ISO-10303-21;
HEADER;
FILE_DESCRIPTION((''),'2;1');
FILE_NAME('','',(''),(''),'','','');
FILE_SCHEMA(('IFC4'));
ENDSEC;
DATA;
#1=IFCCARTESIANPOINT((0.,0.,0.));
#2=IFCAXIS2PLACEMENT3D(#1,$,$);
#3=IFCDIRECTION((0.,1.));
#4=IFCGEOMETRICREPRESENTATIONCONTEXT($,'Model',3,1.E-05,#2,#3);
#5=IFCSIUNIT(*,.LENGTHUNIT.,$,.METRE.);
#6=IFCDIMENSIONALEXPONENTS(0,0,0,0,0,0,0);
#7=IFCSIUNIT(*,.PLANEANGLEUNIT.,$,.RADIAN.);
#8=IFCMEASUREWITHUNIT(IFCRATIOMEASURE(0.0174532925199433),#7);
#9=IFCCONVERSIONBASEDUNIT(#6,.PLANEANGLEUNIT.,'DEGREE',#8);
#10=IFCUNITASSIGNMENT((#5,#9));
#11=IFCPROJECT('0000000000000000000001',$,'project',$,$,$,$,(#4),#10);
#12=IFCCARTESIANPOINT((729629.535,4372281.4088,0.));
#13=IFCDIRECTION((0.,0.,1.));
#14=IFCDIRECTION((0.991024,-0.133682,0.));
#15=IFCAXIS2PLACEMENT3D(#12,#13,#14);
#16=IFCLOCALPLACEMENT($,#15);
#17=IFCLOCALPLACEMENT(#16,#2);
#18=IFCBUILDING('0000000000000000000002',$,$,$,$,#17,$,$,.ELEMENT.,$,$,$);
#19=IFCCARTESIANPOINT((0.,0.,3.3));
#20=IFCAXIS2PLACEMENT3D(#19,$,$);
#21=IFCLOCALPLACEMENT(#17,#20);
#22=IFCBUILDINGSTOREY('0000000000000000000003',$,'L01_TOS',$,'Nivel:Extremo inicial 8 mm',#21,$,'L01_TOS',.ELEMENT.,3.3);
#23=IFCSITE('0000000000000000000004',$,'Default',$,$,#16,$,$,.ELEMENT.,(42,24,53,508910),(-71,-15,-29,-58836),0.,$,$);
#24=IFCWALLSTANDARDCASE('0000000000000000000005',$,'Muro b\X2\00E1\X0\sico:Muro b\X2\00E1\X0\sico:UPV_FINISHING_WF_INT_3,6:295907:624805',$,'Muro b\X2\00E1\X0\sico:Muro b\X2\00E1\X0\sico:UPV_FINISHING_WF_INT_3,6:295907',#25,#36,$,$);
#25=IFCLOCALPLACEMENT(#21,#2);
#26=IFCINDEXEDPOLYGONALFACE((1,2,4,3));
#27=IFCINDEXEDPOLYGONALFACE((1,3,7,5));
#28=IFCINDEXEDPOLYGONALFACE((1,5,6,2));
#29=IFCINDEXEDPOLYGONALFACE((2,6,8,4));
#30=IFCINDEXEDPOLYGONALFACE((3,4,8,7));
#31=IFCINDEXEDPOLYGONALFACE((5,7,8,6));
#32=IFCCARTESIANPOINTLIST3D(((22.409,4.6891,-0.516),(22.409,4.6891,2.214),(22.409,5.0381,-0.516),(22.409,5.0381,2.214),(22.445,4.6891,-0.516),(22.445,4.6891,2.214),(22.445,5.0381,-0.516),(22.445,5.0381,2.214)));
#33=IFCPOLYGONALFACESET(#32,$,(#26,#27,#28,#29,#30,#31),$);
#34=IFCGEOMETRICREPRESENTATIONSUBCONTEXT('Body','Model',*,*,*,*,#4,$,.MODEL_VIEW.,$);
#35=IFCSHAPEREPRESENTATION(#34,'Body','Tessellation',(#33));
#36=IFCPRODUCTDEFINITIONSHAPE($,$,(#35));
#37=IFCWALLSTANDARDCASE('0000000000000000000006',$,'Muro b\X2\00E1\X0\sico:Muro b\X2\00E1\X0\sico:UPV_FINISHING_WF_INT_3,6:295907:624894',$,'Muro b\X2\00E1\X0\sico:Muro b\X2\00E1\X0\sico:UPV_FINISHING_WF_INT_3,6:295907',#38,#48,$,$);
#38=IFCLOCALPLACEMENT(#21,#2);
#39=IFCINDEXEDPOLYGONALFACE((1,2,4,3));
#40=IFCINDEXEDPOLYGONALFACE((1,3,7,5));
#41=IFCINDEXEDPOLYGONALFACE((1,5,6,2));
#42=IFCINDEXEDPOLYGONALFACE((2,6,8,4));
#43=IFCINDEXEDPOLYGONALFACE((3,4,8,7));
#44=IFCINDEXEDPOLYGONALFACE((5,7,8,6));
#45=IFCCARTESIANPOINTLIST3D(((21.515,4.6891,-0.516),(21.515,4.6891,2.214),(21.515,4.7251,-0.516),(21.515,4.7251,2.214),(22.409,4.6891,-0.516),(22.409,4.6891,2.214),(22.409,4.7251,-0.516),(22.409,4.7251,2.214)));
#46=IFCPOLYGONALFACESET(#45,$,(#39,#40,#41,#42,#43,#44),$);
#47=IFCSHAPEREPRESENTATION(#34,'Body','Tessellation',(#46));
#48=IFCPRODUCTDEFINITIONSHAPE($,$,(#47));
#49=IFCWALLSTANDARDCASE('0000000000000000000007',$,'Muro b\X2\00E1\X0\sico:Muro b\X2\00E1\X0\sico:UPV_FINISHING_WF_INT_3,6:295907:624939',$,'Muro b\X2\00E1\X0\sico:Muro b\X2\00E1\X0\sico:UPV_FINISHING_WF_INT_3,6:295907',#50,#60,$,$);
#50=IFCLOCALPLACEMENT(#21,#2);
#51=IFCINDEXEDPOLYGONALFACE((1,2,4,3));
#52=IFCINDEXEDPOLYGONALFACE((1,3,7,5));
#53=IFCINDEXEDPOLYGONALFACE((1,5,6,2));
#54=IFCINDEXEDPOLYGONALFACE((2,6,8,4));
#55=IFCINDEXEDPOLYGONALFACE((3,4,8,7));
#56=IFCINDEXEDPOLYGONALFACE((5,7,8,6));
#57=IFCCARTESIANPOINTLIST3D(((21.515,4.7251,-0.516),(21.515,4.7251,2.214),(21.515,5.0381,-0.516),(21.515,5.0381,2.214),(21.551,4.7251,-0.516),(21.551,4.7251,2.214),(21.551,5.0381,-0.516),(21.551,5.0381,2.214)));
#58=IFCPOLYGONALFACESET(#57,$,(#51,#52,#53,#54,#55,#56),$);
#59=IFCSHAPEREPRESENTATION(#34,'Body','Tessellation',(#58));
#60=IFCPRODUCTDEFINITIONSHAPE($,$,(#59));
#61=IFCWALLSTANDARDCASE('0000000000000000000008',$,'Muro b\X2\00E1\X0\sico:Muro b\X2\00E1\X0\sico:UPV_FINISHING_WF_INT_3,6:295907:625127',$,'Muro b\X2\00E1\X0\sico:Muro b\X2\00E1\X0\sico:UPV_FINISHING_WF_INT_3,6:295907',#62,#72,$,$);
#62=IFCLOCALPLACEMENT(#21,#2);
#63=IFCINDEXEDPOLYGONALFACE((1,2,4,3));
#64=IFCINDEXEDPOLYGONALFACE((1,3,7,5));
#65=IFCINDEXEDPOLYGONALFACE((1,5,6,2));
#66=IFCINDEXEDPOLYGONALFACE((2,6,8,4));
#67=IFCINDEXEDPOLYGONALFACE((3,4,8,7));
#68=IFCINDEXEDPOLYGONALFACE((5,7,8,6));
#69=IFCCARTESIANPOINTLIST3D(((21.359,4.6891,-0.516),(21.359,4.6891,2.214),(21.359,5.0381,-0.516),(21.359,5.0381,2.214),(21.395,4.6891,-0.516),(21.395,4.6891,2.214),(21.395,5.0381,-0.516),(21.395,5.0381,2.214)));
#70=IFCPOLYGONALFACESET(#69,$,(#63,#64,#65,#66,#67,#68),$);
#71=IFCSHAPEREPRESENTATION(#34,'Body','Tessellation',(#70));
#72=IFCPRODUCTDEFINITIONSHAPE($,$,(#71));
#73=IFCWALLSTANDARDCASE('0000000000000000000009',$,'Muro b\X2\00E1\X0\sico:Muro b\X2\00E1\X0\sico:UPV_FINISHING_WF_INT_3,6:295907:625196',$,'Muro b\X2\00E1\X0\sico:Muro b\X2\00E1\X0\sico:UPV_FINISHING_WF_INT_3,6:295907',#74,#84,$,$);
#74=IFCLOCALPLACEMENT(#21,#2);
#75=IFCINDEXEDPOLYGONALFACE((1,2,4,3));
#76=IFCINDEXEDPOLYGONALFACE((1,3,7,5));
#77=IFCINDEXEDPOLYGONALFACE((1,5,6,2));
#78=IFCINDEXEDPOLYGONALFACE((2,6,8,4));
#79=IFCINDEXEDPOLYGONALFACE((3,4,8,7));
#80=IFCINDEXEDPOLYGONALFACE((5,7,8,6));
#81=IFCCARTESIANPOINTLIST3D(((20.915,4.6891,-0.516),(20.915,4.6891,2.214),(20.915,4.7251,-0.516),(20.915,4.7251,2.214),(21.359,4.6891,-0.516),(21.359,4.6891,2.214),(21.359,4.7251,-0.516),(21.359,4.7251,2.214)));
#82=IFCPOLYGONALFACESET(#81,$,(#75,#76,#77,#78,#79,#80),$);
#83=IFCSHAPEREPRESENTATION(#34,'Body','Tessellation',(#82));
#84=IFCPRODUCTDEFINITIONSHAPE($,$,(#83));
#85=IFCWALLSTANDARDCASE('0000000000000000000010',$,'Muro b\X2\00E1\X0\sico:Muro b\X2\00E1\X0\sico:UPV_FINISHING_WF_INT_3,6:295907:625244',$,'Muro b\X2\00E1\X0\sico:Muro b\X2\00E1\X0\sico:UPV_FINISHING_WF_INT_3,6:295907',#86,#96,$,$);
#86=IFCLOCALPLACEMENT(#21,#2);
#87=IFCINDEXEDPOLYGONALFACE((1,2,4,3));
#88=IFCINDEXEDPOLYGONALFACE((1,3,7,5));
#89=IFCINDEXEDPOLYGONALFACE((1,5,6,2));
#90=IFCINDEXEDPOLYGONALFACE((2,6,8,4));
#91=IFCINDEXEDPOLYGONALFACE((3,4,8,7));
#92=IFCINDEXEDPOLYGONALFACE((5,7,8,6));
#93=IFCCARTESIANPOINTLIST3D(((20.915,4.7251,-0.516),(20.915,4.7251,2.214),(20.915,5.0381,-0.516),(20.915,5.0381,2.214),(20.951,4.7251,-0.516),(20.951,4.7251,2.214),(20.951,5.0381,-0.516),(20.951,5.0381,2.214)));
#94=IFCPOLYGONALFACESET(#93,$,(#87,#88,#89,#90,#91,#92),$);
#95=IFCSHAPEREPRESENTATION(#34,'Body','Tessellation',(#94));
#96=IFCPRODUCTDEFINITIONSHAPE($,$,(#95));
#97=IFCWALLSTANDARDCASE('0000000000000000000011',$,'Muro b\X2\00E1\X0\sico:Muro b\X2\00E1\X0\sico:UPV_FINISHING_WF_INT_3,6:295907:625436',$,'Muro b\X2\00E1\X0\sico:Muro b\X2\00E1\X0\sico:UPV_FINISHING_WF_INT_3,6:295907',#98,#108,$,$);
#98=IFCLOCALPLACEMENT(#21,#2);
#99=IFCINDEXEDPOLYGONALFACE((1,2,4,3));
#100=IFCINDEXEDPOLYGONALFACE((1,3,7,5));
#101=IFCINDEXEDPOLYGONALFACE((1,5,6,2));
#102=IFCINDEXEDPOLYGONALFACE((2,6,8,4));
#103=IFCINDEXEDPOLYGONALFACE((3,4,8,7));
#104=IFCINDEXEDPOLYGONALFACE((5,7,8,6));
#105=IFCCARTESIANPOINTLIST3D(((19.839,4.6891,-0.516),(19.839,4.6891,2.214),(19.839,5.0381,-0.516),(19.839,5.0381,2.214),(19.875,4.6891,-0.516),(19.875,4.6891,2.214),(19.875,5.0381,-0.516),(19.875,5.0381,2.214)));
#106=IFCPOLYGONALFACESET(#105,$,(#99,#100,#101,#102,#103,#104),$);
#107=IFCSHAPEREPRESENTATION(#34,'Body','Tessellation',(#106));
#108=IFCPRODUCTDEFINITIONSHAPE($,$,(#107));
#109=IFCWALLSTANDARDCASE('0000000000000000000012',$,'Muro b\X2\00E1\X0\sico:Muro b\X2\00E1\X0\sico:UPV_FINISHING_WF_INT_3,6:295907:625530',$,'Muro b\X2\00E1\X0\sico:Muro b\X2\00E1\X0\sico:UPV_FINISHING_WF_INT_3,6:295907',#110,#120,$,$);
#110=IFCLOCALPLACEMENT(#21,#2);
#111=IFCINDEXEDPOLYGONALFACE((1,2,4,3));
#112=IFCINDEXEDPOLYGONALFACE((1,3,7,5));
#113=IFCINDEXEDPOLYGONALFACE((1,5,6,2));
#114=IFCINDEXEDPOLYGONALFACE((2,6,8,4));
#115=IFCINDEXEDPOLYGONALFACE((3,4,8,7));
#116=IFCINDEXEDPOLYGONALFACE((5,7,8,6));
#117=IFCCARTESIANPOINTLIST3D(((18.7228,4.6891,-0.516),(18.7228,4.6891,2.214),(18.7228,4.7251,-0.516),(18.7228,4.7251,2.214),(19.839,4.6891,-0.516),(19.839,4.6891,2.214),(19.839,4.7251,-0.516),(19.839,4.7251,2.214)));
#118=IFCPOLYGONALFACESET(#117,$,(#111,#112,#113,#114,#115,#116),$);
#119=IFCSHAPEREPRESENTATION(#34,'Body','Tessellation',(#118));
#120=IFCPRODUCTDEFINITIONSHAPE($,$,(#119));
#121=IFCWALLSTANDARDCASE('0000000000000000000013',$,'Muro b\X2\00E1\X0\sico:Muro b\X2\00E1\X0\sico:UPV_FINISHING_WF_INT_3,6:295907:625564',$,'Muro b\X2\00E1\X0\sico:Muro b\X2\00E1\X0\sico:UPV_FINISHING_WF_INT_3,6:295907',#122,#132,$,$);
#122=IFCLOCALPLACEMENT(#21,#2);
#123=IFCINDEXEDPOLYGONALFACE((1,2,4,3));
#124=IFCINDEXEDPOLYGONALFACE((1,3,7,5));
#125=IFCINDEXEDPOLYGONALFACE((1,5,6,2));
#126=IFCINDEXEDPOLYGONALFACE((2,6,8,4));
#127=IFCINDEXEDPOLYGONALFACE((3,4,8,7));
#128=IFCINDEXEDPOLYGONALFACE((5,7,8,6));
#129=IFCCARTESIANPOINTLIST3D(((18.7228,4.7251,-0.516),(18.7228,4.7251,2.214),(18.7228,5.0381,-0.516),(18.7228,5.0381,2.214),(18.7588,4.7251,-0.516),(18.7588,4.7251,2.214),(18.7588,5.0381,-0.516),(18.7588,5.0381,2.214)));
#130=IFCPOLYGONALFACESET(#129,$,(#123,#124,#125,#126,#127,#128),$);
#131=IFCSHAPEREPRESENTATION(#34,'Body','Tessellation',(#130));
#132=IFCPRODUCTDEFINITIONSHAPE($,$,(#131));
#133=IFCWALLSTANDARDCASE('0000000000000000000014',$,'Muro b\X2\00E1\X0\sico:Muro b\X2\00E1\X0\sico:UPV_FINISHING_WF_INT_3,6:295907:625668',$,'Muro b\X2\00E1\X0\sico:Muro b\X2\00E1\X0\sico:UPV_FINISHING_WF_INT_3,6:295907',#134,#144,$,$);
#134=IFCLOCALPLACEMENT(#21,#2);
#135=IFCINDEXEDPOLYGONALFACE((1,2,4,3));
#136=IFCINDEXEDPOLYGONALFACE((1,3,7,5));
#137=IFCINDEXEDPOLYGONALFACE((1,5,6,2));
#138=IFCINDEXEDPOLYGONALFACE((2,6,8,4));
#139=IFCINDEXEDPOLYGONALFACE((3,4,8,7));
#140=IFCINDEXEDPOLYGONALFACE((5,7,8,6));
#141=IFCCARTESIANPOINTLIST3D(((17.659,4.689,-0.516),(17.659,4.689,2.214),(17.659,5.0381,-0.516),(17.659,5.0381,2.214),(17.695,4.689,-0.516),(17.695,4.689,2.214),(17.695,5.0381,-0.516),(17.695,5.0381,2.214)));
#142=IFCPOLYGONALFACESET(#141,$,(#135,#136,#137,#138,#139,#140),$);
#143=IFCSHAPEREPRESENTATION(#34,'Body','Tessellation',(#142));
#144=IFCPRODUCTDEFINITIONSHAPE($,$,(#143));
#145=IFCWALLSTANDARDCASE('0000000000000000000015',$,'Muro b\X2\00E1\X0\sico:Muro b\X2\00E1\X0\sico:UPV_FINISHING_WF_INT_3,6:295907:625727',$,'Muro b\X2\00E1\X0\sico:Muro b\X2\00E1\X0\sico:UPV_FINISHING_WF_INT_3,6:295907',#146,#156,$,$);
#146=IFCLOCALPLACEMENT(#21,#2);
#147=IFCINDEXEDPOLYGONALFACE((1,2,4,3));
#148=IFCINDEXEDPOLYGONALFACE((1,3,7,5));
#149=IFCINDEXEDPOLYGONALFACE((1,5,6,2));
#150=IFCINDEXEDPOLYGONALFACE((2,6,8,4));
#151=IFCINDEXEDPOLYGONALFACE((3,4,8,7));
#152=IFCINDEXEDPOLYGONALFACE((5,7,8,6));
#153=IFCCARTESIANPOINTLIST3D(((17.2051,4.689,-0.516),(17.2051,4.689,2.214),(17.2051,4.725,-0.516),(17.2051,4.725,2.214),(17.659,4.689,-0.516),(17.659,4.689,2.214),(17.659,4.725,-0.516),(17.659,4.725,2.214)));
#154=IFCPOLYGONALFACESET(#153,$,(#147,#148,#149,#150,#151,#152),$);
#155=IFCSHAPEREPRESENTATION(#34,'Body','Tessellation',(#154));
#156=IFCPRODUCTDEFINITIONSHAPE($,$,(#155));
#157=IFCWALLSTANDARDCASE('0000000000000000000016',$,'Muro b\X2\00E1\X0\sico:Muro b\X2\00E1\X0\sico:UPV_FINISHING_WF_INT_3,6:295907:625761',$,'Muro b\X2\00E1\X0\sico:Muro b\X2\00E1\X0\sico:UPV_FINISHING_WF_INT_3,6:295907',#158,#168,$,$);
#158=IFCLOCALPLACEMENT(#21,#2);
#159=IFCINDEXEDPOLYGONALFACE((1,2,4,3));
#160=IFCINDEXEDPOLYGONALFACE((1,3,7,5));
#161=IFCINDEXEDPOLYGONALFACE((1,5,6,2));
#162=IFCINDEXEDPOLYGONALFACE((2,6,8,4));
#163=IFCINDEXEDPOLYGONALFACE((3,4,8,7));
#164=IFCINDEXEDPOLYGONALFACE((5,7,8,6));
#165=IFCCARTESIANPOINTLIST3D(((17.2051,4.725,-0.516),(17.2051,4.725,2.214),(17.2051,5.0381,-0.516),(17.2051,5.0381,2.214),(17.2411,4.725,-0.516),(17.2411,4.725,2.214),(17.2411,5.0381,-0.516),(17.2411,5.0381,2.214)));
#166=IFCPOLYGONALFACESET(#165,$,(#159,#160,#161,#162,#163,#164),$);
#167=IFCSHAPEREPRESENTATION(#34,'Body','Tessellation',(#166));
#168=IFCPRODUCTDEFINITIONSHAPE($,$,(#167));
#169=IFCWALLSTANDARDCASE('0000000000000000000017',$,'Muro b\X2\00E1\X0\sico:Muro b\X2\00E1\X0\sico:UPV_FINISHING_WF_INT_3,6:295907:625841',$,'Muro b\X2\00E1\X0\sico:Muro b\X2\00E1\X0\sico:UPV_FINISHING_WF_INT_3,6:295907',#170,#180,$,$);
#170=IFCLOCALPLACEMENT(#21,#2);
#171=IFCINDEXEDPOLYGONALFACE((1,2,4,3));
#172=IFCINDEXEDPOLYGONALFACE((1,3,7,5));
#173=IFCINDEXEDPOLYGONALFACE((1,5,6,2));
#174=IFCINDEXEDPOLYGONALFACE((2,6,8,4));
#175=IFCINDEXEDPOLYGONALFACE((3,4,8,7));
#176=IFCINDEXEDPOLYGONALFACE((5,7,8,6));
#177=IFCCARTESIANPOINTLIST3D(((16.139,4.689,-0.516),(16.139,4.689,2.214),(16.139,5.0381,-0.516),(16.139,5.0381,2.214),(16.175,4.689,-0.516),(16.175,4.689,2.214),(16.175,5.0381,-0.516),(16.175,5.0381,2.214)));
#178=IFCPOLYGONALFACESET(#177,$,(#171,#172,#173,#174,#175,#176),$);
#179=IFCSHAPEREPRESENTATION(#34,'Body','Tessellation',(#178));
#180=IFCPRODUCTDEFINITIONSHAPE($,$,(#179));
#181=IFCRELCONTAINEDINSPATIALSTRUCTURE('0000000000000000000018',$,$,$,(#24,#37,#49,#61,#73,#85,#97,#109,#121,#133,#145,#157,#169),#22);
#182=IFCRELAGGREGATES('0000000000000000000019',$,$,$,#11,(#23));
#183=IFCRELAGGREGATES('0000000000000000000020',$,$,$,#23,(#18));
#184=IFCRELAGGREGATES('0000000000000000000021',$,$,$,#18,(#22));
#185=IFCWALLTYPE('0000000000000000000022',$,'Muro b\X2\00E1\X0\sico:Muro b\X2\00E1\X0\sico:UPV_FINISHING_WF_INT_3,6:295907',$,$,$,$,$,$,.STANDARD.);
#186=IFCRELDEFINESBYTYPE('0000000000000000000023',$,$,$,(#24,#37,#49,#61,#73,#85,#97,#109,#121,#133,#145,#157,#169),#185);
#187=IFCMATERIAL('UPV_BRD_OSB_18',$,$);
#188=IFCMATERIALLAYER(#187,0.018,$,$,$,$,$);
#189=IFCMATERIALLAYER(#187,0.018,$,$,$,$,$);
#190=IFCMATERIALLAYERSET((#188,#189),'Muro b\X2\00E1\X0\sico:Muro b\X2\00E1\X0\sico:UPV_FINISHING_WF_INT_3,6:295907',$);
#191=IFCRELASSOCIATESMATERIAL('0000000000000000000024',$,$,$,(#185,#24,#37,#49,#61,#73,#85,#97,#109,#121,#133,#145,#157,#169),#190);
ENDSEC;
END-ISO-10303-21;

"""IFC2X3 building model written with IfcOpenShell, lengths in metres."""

from ifc_helpers import new_model, entity, si_unit, converted_unit, direction, frame, frame_2d, origin, place, context, subcontext, project, spatial, rectangle, extrude, material, layer, layer_set, layer_usage, type_object, element, save


model = new_model("IFC2X3")

# Units and contexts
model_context = context("Model", 3, precision=1e-05, world=origin(), true_north=direction((0.0, 1.0)))
body_context = subcontext(model_context, "Body", "Model", "MODEL_VIEW")
ifc_project = project(units=[si_unit("LENGTHUNIT", "METRE"), converted_unit("PLANEANGLEUNIT", "DEGREE", entity("IfcRatioMeasure", 0.0174532925199433), si_unit("PLANEANGLEUNIT", "RADIAN"), dimensions=[0, 0, 0, 0, 0, 0, 0])], contexts=[model_context])

# Site, building, storey
site_placement = place(None, frame((729629.535, 4372281.4088, 0.0), z_axis=(0.0, 0.0, 1.0), x_axis=(0.991024, -0.133682, 0.0)))
site = spatial("IfcSite", under=ifc_project, at=site_placement, Name="Default", CompositionType="ELEMENT", RefLatitude=(42, 24, 53, 508910), RefLongitude=(-71, -15, -29, -58836), RefElevation=0.0)
building_placement = place(site_placement, origin())
building = spatial("IfcBuilding", under=site, at=building_placement, CompositionType="ELEMENT")
storey_placement = place(building_placement, frame((0.0, 0.0, 3.3)))
storey = spatial("IfcBuildingStorey", under=building, at=storey_placement, Name="L01_TOS", ObjectType="Nivel:Extremo inicial 8 mm", LongName="L01_TOS", CompositionType="ELEMENT", Elevation=3.3)

# Walls
ifc_material_1 = material(Name="UPV_BRD_OSB_18")
ifc_layer_1 = layer(ifc_material_1, 0.018)
ifc_layer_2 = layer(ifc_material_1, 0.018)
ifc_layer_set_1 = layer_set([ifc_layer_1, ifc_layer_2], Name="Muro básico:Muro básico:UPV_FINISHING_WF_INT_3,6:295907")
ifc_layer_usage_1 = layer_usage(ifc_layer_set_1, "AXIS2", "NEGATIVE", 0.018)
wall_type_1 = type_object("IfcWallType", Name="Muro básico:Muro básico:UPV_FINISHING_WF_INT_3,6:295907", PredefinedType="STANDARD", material=ifc_layer_set_1)
wall_1_placement = place(storey_placement, frame((22.427, 5.0381, -0.516), z_axis=(0.0, 0.0, 1.0), x_axis=(0.0, -1.0, 0.0)))
element("IfcWallStandardCase", 1, at=wall_1_placement, inside=storey, type_object=wall_type_1, material=ifc_layer_usage_1, Name="Muro básico:Muro básico:UPV_FINISHING_WF_INT_3,6:295907:624805", ObjectType="Muro básico:Muro básico:UPV_FINISHING_WF_INT_3,6:295907", context=body_context, shape_type="SweptSolid", body=[
    extrude(rectangle(XDim=0.349, YDim=0.036, at=frame_2d((0.1745, 0.0), x_axis=(-1.0, 0.0))), origin(), (0.0, 0.0, 1.0), 2.73),
])
ifc_layer_usage_2 = layer_usage(ifc_layer_set_1, "AXIS2", "POSITIVE", -0.018)
wall_2_placement = place(storey_placement, frame((22.409, 4.7071, -0.516), z_axis=(0.0, 0.0, 1.0), x_axis=(-1.0, -0.000012, 0.0)))
element("IfcWallStandardCase", 2, at=wall_2_placement, inside=storey, type_object=wall_type_1, material=ifc_layer_usage_2, Name="Muro básico:Muro básico:UPV_FINISHING_WF_INT_3,6:295907:624894", ObjectType="Muro básico:Muro básico:UPV_FINISHING_WF_INT_3,6:295907", context=body_context, shape_type="SweptSolid", body=[
    extrude(rectangle(XDim=0.894, YDim=0.036, at=frame_2d((0.447, 0.0), x_axis=(-1.0, 0.0))), origin(), (0.0, 0.0, 1.0), 2.73),
])
ifc_layer_usage_3 = layer_usage(ifc_layer_set_1, "AXIS2", "NEGATIVE", 0.018)
wall_3_placement = place(storey_placement, frame((21.533, 4.7251, -0.516), z_axis=(0.0, 0.0, 1.0), x_axis=(0.0, 1.0, 0.0)))
element("IfcWallStandardCase", 3, at=wall_3_placement, inside=storey, type_object=wall_type_1, material=ifc_layer_usage_3, Name="Muro básico:Muro básico:UPV_FINISHING_WF_INT_3,6:295907:624939", ObjectType="Muro básico:Muro básico:UPV_FINISHING_WF_INT_3,6:295907", context=body_context, shape_type="SweptSolid", body=[
    extrude(rectangle(XDim=0.313, YDim=0.036, at=frame_2d((0.1565, 0.0), x_axis=(-1.0, 0.0))), origin(), (0.0, 0.0, 1.0), 2.73),
])
ifc_layer_usage_4 = layer_usage(ifc_layer_set_1, "AXIS2", "NEGATIVE", 0.018)
wall_4_placement = place(storey_placement, frame((21.377, 5.0381, -0.516), z_axis=(0.0, 0.0, 1.0), x_axis=(0.0, -1.0, 0.0)))
element("IfcWallStandardCase", 4, at=wall_4_placement, inside=storey, type_object=wall_type_1, material=ifc_layer_usage_4, Name="Muro básico:Muro básico:UPV_FINISHING_WF_INT_3,6:295907:625127", ObjectType="Muro básico:Muro básico:UPV_FINISHING_WF_INT_3,6:295907", context=body_context, shape_type="SweptSolid", body=[
    extrude(rectangle(XDim=0.349, YDim=0.036, at=frame_2d((0.1745, 0.0), x_axis=(-1.0, 0.0))), origin(), (0.0, 0.0, 1.0), 2.73),
])
ifc_layer_usage_5 = layer_usage(ifc_layer_set_1, "AXIS2", "NEGATIVE", 0.018)
wall_5_placement = place(storey_placement, frame((21.359, 4.7071, -0.516), z_axis=(0.0, 0.0, 1.0), x_axis=(-1.0, -0.000012, 0.0)))
element("IfcWallStandardCase", 5, at=wall_5_placement, inside=storey, type_object=wall_type_1, material=ifc_layer_usage_5, Name="Muro básico:Muro básico:UPV_FINISHING_WF_INT_3,6:295907:625196", ObjectType="Muro básico:Muro básico:UPV_FINISHING_WF_INT_3,6:295907", context=body_context, shape_type="SweptSolid", body=[
    extrude(rectangle(XDim=0.444, YDim=0.036, at=frame_2d((0.222, 0.0), x_axis=(-1.0, 0.0))), origin(), (0.0, 0.0, 1.0), 2.73),
])
ifc_layer_usage_6 = layer_usage(ifc_layer_set_1, "AXIS2", "NEGATIVE", 0.018)
wall_6_placement = place(storey_placement, frame((20.933, 4.7251, -0.516), z_axis=(0.0, 0.0, 1.0), x_axis=(0.0, 1.0, 0.0)))
element("IfcWallStandardCase", 6, at=wall_6_placement, inside=storey, type_object=wall_type_1, material=ifc_layer_usage_6, Name="Muro básico:Muro básico:UPV_FINISHING_WF_INT_3,6:295907:625244", ObjectType="Muro básico:Muro básico:UPV_FINISHING_WF_INT_3,6:295907", context=body_context, shape_type="SweptSolid", body=[
    extrude(rectangle(XDim=0.313, YDim=0.036, at=frame_2d((0.1565, 0.0), x_axis=(-1.0, 0.0))), origin(), (0.0, 0.0, 1.0), 2.73),
])
ifc_layer_usage_7 = layer_usage(ifc_layer_set_1, "AXIS2", "NEGATIVE", 0.018)
wall_7_placement = place(storey_placement, frame((19.857, 5.0381, -0.516), z_axis=(0.0, 0.0, 1.0), x_axis=(0.0, -1.0, 0.0)))
element("IfcWallStandardCase", 7, at=wall_7_placement, inside=storey, type_object=wall_type_1, material=ifc_layer_usage_7, Name="Muro básico:Muro básico:UPV_FINISHING_WF_INT_3,6:295907:625436", ObjectType="Muro básico:Muro básico:UPV_FINISHING_WF_INT_3,6:295907", context=body_context, shape_type="SweptSolid", body=[
    extrude(rectangle(XDim=0.349, YDim=0.036, at=frame_2d((0.1745, 0.0), x_axis=(-1.0, 0.0))), origin(), (0.0, 0.0, 1.0), 2.73),
])
ifc_layer_usage_8 = layer_usage(ifc_layer_set_1, "AXIS2", "NEGATIVE", 0.018)
wall_8_placement = place(storey_placement, frame((19.839, 4.7071, -0.516), z_axis=(0.0, 0.0, 1.0), x_axis=(-1.0, -0.000012, 0.0)))
element("IfcWallStandardCase", 8, at=wall_8_placement, inside=storey, type_object=wall_type_1, material=ifc_layer_usage_8, Name="Muro básico:Muro básico:UPV_FINISHING_WF_INT_3,6:295907:625530", ObjectType="Muro básico:Muro básico:UPV_FINISHING_WF_INT_3,6:295907", context=body_context, shape_type="SweptSolid", body=[
    extrude(rectangle(XDim=1.1162, YDim=0.036, at=frame_2d((0.5581, 0.0), x_axis=(-1.0, 0.0))), origin(), (0.0, 0.0, 1.0), 2.73),
])
ifc_layer_usage_9 = layer_usage(ifc_layer_set_1, "AXIS2", "NEGATIVE", 0.018)
wall_9_placement = place(storey_placement, frame((18.7408, 4.7251, -0.516), z_axis=(0.0, 0.0, 1.0), x_axis=(0.0, 1.0, 0.0)))
element("IfcWallStandardCase", 9, at=wall_9_placement, inside=storey, type_object=wall_type_1, material=ifc_layer_usage_9, Name="Muro básico:Muro básico:UPV_FINISHING_WF_INT_3,6:295907:625564", ObjectType="Muro básico:Muro básico:UPV_FINISHING_WF_INT_3,6:295907", context=body_context, shape_type="SweptSolid", body=[
    extrude(rectangle(XDim=0.313, YDim=0.036, at=frame_2d((0.1565, 0.0), x_axis=(-1.0, 0.0))), origin(), (0.0, 0.0, 1.0), 2.73),
])
ifc_layer_usage_10 = layer_usage(ifc_layer_set_1, "AXIS2", "NEGATIVE", 0.018)
wall_10_placement = place(storey_placement, frame((17.677, 5.0381, -0.516), z_axis=(0.0, 0.0, 1.0), x_axis=(0.0, -1.0, 0.0)))
element("IfcWallStandardCase", 10, at=wall_10_placement, inside=storey, type_object=wall_type_1, material=ifc_layer_usage_10, Name="Muro básico:Muro básico:UPV_FINISHING_WF_INT_3,6:295907:625668", ObjectType="Muro básico:Muro básico:UPV_FINISHING_WF_INT_3,6:295907", context=body_context, shape_type="SweptSolid", body=[
    extrude(rectangle(XDim=0.349, YDim=0.036, at=frame_2d((0.1745, 0.0), x_axis=(-1.0, 0.0))), origin(), (0.0, 0.0, 1.0), 2.73),
])
ifc_layer_usage_11 = layer_usage(ifc_layer_set_1, "AXIS2", "NEGATIVE", 0.018)
wall_11_placement = place(storey_placement, frame((17.659, 4.707, -0.516), z_axis=(0.0, 0.0, 1.0), x_axis=(-1.0, -0.000012, 0.0)))
element("IfcWallStandardCase", 11, at=wall_11_placement, inside=storey, type_object=wall_type_1, material=ifc_layer_usage_11, Name="Muro básico:Muro básico:UPV_FINISHING_WF_INT_3,6:295907:625727", ObjectType="Muro básico:Muro básico:UPV_FINISHING_WF_INT_3,6:295907", context=body_context, shape_type="SweptSolid", body=[
    extrude(rectangle(XDim=0.4539, YDim=0.036, at=frame_2d((0.227, 0.0), x_axis=(-1.0, 0.0))), origin(), (0.0, 0.0, 1.0), 2.73),
])
ifc_layer_usage_12 = layer_usage(ifc_layer_set_1, "AXIS2", "NEGATIVE", 0.018)
wall_12_placement = place(storey_placement, frame((17.2231, 4.725, -0.516), z_axis=(0.0, 0.0, 1.0), x_axis=(0.0, 1.0, 0.0)))
element("IfcWallStandardCase", 12, at=wall_12_placement, inside=storey, type_object=wall_type_1, material=ifc_layer_usage_12, Name="Muro básico:Muro básico:UPV_FINISHING_WF_INT_3,6:295907:625761", ObjectType="Muro básico:Muro básico:UPV_FINISHING_WF_INT_3,6:295907", context=body_context, shape_type="SweptSolid", body=[
    extrude(rectangle(XDim=0.313, YDim=0.036, at=frame_2d((0.1565, 0.0), x_axis=(-1.0, 0.0))), origin(), (0.0, 0.0, 1.0), 2.73),
])
ifc_layer_usage_13 = layer_usage(ifc_layer_set_1, "AXIS2", "NEGATIVE", 0.018)
wall_13_placement = place(storey_placement, frame((16.157, 5.0381, -0.516), z_axis=(0.0, 0.0, 1.0), x_axis=(0.0, -1.0, 0.0)))
element("IfcWallStandardCase", 13, at=wall_13_placement, inside=storey, type_object=wall_type_1, material=ifc_layer_usage_13, Name="Muro básico:Muro básico:UPV_FINISHING_WF_INT_3,6:295907:625841", ObjectType="Muro básico:Muro básico:UPV_FINISHING_WF_INT_3,6:295907", context=body_context, shape_type="SweptSolid", body=[
    extrude(rectangle(XDim=0.349, YDim=0.036, at=frame_2d((0.1745, 0.0), x_axis=(-1.0, 0.0))), origin(), (0.0, 0.0, 1.0), 2.73),
])

save(model, "model.ifc")
